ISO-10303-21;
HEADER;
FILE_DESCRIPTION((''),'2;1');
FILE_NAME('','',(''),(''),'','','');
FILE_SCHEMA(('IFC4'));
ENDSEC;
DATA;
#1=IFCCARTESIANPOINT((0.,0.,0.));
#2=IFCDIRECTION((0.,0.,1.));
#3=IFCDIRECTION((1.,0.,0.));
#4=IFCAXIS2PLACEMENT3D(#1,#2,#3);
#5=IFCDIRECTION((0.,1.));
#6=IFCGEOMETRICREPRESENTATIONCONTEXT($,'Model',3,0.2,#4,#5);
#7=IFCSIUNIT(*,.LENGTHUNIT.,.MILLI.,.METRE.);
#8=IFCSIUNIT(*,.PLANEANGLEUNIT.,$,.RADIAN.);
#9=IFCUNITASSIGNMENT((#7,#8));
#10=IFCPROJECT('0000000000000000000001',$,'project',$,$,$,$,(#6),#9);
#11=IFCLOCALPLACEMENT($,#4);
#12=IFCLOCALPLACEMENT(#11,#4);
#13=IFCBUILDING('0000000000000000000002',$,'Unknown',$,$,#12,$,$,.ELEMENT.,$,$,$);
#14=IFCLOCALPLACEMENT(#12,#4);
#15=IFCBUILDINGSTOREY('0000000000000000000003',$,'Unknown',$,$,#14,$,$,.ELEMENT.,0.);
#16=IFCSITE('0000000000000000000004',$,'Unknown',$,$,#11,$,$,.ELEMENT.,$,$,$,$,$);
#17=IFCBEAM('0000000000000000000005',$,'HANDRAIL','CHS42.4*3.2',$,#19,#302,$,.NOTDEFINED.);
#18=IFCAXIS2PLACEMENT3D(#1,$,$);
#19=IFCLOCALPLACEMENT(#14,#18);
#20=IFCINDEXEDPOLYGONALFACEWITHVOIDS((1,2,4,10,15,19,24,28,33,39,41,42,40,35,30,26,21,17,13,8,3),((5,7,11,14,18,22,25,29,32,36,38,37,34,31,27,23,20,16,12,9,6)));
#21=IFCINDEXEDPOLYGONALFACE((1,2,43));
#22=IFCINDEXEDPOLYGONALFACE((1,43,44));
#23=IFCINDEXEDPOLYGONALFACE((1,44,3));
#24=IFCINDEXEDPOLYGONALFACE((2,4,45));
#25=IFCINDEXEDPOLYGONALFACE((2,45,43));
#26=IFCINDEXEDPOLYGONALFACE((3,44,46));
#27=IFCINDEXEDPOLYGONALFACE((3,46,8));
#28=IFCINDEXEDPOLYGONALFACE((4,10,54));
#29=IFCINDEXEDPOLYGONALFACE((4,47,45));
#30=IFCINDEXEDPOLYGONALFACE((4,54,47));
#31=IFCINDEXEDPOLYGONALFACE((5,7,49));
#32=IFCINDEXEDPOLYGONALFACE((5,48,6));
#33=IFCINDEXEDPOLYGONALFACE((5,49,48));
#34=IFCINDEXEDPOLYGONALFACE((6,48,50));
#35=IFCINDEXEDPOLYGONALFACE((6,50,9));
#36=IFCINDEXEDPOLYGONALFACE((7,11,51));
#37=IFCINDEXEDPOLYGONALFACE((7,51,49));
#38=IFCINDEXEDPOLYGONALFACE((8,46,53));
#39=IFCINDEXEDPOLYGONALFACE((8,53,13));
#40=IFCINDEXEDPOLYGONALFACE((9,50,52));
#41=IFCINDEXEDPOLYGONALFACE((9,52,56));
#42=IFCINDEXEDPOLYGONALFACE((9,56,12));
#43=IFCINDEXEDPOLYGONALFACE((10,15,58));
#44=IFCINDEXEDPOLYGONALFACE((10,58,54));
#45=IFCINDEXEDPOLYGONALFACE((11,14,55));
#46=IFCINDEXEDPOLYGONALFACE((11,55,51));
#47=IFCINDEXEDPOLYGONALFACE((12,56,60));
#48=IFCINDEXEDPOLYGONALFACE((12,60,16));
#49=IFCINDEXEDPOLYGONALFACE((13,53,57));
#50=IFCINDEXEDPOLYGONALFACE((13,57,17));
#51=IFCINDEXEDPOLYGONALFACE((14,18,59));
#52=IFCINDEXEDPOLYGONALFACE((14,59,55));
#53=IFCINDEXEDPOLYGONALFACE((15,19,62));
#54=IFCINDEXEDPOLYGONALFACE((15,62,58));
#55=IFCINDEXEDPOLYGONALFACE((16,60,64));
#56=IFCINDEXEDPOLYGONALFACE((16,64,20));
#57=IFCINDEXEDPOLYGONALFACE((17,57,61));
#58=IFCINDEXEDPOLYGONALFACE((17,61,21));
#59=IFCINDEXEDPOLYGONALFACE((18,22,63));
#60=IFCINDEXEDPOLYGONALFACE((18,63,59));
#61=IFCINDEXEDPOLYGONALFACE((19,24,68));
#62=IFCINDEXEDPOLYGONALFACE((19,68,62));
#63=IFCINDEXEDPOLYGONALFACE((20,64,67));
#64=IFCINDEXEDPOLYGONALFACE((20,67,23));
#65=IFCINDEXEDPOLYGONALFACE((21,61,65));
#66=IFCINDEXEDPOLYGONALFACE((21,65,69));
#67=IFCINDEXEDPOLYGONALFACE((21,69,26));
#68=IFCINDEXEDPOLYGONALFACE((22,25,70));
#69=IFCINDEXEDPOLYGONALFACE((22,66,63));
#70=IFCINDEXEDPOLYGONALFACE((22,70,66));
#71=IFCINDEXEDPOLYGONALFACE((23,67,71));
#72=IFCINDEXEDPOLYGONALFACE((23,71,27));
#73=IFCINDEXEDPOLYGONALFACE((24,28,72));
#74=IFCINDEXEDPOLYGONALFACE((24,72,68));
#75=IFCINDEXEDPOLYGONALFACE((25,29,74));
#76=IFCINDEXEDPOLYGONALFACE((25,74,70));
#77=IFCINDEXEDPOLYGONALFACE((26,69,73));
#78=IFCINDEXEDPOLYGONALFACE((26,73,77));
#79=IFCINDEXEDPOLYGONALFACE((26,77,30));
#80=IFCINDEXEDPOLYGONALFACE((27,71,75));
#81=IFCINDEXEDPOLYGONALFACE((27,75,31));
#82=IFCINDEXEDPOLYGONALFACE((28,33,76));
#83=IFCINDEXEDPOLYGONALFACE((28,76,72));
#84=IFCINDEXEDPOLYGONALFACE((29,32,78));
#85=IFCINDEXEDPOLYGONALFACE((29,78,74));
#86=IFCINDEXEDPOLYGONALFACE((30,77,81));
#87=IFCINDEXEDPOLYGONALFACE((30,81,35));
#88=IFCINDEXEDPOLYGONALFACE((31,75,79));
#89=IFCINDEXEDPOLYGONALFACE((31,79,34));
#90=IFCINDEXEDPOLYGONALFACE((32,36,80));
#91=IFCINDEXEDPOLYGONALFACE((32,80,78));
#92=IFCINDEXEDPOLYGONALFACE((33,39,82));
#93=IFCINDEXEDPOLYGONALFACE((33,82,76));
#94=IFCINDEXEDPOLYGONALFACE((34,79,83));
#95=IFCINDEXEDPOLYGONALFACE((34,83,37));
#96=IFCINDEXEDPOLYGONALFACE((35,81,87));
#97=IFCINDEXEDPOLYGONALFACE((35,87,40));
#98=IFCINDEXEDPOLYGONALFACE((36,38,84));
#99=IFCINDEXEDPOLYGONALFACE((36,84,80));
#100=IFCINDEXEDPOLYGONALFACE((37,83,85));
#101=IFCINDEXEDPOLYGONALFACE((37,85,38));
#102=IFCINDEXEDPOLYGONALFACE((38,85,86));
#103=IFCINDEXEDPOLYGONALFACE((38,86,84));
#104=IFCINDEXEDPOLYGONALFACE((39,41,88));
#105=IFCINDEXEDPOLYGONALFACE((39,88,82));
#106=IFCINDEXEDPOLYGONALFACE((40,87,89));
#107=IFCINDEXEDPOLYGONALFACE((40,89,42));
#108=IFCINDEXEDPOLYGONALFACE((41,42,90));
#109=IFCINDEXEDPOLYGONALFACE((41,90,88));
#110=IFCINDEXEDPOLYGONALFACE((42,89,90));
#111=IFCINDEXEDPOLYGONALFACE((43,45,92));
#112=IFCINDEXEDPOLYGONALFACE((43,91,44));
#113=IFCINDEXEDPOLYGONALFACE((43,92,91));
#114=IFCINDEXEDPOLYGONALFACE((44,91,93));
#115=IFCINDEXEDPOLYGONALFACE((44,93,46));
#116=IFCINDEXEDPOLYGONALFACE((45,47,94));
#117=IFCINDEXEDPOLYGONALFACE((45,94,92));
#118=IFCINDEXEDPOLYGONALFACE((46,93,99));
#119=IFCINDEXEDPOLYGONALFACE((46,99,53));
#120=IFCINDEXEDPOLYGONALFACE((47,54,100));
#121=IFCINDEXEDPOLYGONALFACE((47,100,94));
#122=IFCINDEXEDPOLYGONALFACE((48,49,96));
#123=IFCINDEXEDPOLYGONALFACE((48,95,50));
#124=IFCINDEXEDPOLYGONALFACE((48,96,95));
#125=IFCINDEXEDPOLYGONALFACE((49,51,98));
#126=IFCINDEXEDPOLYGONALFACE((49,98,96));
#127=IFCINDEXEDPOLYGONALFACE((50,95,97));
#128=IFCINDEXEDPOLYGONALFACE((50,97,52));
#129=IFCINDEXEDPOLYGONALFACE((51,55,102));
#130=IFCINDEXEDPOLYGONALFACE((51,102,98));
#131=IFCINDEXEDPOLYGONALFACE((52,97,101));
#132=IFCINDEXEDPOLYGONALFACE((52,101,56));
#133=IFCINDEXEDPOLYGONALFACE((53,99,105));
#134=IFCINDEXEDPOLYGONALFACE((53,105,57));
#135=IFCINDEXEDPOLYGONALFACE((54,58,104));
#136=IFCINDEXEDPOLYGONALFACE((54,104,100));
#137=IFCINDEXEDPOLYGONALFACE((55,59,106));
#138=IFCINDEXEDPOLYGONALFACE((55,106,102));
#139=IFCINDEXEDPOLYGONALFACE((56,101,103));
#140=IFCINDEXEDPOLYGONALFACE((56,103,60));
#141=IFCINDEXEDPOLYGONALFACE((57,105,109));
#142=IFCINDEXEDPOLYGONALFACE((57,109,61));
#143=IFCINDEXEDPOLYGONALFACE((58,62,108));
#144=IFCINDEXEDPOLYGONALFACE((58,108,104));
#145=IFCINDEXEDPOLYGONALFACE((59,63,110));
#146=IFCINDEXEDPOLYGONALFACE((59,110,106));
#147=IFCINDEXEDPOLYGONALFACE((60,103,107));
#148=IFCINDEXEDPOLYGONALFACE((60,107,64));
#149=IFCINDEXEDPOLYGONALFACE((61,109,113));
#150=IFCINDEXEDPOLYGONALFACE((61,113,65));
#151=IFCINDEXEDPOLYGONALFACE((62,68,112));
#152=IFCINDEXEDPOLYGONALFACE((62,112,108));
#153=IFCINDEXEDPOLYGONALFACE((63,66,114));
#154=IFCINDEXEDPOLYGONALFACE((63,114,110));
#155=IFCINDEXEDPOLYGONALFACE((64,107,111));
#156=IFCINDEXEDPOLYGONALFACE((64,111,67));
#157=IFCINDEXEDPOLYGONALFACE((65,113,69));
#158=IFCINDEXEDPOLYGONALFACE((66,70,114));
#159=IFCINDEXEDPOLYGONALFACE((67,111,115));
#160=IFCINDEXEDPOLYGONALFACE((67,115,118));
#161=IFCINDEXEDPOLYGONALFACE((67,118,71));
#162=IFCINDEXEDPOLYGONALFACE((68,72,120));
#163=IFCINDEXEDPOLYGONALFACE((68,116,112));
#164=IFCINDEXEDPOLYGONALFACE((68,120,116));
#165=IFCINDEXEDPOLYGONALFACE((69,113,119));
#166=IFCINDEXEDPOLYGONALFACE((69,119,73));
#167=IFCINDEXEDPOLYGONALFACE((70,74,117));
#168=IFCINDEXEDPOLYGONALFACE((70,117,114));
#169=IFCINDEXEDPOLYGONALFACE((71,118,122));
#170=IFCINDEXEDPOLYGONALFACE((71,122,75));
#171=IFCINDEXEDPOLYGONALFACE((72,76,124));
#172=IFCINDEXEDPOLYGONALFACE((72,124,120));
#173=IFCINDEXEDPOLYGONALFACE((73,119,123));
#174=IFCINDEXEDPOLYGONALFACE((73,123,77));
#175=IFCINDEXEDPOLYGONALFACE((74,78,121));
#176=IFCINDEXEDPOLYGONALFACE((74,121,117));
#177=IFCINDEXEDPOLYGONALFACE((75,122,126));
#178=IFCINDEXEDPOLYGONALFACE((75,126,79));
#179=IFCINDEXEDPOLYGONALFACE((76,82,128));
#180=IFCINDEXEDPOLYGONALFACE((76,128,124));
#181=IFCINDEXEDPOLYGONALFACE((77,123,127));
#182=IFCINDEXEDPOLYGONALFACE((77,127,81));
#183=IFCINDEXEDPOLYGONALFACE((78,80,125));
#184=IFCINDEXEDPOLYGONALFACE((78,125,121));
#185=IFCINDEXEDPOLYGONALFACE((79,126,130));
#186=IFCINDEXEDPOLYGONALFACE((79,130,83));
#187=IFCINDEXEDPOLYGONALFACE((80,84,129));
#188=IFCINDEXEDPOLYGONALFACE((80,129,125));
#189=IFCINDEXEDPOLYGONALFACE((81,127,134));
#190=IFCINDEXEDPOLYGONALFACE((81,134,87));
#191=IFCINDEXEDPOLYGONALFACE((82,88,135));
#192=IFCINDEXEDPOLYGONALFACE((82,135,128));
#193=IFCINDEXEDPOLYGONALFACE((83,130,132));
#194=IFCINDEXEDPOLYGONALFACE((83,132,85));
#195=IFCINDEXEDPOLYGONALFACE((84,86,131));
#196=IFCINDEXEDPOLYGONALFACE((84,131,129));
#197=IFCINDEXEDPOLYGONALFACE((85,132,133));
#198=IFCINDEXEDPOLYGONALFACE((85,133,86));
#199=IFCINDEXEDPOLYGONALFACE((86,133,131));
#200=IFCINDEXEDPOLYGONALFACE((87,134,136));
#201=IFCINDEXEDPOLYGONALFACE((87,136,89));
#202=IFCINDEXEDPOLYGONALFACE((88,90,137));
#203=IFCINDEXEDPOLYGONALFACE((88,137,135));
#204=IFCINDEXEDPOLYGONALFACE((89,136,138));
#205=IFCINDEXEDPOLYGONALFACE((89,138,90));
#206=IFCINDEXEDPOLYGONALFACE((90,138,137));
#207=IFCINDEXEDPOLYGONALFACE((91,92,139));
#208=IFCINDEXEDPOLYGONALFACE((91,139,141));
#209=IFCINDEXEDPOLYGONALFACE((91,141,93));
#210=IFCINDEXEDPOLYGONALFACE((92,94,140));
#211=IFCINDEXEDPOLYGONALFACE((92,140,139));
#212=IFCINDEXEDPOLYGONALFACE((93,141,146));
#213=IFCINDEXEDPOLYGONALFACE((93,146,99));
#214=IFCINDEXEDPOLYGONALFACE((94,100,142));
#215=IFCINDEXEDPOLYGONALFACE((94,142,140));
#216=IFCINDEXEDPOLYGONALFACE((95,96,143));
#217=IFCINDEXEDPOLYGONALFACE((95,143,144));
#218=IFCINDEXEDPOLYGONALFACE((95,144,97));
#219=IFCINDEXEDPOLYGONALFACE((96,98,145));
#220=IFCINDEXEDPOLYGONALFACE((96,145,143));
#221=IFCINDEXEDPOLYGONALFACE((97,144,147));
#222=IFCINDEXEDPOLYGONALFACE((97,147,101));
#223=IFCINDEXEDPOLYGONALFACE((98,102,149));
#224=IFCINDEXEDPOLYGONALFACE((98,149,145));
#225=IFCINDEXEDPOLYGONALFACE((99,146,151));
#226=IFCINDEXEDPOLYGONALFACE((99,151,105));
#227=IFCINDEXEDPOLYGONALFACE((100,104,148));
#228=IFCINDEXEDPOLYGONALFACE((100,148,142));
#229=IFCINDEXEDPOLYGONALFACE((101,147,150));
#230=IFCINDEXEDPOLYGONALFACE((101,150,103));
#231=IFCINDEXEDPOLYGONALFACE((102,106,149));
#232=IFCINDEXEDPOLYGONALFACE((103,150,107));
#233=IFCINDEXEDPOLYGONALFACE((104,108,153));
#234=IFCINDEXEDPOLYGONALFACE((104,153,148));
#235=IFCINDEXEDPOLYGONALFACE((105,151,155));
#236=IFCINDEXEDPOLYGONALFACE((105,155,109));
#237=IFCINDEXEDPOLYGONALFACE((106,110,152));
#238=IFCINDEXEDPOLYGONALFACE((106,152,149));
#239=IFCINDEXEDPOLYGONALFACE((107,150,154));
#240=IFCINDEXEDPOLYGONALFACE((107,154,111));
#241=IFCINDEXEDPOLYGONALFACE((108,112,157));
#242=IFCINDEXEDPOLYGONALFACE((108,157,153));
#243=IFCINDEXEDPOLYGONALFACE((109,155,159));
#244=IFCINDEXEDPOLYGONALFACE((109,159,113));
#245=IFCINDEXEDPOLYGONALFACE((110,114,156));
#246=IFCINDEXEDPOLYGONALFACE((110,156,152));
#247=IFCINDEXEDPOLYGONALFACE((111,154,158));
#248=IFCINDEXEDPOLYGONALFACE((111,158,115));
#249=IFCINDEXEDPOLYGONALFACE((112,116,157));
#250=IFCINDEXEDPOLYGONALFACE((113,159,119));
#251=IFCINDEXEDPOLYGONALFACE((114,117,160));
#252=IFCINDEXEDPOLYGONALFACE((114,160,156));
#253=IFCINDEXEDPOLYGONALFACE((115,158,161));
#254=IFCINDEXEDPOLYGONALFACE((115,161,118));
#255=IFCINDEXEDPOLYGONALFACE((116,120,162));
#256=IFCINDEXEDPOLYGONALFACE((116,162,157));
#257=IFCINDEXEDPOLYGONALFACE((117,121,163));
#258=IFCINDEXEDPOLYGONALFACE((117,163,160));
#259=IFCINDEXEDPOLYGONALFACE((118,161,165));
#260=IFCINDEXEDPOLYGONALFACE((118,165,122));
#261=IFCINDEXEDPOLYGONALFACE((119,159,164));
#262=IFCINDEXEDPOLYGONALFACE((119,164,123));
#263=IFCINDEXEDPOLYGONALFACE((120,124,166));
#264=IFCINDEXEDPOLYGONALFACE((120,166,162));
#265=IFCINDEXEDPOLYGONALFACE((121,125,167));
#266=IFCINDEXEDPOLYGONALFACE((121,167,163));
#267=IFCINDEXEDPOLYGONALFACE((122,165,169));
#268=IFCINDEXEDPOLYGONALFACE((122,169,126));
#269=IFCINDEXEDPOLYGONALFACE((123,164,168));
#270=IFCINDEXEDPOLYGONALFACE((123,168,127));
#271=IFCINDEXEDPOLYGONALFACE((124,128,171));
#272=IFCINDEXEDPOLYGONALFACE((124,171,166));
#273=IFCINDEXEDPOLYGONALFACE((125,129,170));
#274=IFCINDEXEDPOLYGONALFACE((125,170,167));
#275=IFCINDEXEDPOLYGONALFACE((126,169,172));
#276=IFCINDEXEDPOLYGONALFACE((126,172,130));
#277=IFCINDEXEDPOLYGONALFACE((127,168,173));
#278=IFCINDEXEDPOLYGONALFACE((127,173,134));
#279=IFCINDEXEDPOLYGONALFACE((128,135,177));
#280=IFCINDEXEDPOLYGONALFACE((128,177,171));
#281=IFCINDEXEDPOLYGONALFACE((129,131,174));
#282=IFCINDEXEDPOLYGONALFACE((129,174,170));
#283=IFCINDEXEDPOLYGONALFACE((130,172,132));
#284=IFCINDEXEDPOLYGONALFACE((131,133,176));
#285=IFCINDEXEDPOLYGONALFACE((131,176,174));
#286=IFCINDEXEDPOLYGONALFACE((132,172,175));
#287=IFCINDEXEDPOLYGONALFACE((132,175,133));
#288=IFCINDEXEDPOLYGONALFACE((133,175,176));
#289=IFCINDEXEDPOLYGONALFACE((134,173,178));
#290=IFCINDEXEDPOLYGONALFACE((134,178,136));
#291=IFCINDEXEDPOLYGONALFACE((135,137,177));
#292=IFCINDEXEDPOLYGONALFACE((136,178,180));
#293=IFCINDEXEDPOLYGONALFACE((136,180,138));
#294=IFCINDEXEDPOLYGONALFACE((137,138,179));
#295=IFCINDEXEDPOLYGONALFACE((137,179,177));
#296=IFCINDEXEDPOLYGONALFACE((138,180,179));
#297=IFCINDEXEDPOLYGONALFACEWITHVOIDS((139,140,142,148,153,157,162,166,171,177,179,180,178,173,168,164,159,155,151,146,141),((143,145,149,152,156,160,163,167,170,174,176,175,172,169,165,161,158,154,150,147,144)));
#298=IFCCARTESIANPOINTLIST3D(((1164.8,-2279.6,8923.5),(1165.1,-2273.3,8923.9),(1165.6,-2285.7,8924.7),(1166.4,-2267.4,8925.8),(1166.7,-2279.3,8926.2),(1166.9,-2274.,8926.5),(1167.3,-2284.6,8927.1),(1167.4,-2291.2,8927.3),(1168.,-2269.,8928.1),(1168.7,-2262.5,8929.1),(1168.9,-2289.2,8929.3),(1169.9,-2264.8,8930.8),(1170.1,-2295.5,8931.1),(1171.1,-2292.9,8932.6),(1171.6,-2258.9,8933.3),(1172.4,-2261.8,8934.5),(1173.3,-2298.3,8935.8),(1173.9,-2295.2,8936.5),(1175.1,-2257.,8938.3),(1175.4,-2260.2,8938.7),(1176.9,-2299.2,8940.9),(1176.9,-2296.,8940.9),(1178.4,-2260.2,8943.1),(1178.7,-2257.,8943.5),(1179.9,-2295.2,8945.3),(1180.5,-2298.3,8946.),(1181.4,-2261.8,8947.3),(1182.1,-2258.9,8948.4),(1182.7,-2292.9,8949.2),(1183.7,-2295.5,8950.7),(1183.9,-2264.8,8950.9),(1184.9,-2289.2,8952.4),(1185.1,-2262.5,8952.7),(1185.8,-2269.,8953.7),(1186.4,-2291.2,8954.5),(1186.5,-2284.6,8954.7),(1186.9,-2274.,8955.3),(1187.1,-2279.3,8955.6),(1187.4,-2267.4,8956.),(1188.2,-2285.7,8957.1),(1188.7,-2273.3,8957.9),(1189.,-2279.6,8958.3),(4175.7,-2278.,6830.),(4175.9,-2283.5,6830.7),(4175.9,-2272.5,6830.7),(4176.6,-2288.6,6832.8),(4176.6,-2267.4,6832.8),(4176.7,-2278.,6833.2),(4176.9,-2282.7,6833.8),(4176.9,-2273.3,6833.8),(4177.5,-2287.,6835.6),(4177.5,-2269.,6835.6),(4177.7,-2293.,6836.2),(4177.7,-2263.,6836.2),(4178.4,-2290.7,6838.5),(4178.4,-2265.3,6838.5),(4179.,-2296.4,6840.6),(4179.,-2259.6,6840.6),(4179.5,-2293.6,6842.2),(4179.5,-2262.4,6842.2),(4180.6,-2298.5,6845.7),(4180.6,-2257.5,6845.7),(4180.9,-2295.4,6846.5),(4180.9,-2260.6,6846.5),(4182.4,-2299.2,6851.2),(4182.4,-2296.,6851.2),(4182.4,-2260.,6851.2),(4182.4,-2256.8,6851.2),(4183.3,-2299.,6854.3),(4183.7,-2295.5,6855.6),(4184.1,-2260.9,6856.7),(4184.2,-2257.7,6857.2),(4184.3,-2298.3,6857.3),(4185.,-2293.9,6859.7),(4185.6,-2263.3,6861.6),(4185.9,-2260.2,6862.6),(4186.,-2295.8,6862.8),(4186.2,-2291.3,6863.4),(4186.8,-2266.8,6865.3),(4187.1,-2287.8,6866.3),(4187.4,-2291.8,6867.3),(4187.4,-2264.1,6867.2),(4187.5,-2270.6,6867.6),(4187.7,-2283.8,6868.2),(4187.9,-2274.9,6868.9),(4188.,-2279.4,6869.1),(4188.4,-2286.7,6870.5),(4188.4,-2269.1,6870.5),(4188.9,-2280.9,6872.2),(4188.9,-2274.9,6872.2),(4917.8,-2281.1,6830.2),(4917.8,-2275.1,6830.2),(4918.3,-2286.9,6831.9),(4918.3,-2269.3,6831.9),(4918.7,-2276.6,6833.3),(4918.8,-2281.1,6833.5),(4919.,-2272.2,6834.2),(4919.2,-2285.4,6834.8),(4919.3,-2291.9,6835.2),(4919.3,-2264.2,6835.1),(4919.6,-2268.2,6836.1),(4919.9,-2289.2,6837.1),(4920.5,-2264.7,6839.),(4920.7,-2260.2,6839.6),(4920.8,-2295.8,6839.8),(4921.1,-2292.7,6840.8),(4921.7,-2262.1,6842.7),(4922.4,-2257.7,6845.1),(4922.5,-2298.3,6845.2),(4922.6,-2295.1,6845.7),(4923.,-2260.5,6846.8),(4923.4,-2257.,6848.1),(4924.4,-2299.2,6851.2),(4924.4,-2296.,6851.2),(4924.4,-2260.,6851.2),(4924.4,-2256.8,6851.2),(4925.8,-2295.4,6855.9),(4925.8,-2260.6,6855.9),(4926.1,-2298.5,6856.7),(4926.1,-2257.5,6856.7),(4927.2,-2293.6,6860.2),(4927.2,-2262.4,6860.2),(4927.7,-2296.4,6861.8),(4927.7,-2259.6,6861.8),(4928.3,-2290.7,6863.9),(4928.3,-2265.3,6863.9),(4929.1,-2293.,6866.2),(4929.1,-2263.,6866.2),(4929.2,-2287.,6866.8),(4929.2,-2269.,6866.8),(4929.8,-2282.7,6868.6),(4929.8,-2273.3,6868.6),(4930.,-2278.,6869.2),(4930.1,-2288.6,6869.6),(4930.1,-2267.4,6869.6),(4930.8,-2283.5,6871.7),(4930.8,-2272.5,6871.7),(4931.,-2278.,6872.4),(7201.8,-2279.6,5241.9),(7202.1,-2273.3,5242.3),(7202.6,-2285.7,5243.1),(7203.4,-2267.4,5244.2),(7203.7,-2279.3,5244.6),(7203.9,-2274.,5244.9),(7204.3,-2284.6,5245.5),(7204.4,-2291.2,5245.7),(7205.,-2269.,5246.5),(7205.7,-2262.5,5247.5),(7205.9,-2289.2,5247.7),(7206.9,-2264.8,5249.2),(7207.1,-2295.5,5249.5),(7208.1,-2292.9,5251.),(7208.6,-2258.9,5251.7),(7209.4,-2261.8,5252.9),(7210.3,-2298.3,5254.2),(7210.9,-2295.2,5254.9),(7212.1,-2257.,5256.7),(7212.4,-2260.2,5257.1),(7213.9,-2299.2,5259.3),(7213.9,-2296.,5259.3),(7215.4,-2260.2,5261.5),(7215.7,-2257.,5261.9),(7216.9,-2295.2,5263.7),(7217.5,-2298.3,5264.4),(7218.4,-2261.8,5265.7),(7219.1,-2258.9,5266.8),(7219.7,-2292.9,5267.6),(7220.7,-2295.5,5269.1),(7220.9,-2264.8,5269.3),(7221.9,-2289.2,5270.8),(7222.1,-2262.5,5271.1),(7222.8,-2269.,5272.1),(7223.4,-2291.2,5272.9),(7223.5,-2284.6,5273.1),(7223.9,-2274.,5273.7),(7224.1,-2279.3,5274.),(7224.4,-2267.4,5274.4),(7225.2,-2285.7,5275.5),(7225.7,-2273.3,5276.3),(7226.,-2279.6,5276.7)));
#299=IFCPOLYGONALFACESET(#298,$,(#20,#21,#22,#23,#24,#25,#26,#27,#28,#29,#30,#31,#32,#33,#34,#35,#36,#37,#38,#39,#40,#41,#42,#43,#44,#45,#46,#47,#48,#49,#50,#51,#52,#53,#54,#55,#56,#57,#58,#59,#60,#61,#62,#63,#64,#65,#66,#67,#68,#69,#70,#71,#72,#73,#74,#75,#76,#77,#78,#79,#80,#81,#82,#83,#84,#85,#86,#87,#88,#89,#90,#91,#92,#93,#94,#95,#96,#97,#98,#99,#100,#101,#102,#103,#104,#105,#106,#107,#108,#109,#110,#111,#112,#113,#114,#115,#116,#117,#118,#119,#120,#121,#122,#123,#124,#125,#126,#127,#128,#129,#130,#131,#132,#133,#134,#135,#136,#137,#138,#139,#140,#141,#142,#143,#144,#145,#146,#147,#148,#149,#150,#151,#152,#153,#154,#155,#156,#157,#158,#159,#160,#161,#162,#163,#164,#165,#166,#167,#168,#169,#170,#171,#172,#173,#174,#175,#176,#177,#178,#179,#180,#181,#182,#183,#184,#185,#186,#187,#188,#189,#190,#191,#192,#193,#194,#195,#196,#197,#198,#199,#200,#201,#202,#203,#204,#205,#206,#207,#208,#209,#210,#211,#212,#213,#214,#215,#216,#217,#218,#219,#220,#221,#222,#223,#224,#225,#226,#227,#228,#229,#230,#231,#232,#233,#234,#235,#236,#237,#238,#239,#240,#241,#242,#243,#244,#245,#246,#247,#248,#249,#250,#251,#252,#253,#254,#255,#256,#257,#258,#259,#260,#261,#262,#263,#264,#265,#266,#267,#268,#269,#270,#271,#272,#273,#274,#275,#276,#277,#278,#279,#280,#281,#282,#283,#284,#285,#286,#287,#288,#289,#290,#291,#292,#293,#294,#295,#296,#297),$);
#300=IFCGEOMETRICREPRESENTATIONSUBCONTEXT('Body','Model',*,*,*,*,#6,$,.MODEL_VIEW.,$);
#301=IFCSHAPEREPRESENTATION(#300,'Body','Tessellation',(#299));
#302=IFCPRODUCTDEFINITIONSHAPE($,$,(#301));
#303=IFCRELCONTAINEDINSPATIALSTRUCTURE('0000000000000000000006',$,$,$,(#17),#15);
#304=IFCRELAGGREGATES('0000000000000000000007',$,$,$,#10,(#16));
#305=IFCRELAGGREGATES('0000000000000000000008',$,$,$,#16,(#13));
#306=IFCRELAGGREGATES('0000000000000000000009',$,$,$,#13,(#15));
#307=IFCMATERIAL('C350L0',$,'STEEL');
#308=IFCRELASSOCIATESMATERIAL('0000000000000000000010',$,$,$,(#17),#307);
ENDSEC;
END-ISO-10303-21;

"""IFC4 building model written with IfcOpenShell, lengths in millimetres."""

from ifc_helpers import new_model, entity, si_unit, direction, frame, origin_with_axes, place, context, subcontext, project, spatial, material, element, save


model = new_model("IFC4")

# Units and contexts
model_context = context("Model", 3, precision=0.2, world=origin_with_axes(), true_north=direction((0.0, 1.0)))
body_context = subcontext(model_context, "Body", "Model", "MODEL_VIEW")
ifc_project = project(units=[si_unit("LENGTHUNIT", "METRE", prefix="MILLI"), si_unit("PLANEANGLEUNIT", "RADIAN")], contexts=[model_context])

# Site, building, storey
site_placement = place(None, origin_with_axes())
site = spatial("IfcSite", under=ifc_project, at=site_placement, Name="Unknown", CompositionType="ELEMENT")
building_placement = place(site_placement, origin_with_axes())
building = spatial("IfcBuilding", under=site, at=building_placement, Name="Unknown", CompositionType="ELEMENT")
storey_placement = place(building_placement, origin_with_axes())
storey = spatial("IfcBuildingStorey", under=building, at=storey_placement, Name="Unknown", CompositionType="ELEMENT", Elevation=0.0)

# Shared definitions
ifc_material_1 = material(Name="C350L0", Category="STEEL")

# Beam
for number, where, z_axis, x_axis, name in (
    (1, (1176.9, -2278.0, 8940.9), (0.0, -1.0, 0.0), (0.821041, 0.0, -0.57087), "HANDRAIL"),
):
    element("IfcBeam", number, at=place(storey_placement, frame(where, z_axis=z_axis, x_axis=x_axis)), inside=storey, material=ifc_material_1, Name=name, Description="CHS42.4*3.2", PredefinedType="NOTDEFINED", context=body_context, shape_type="SolidModel", body=[
        entity("IfcSweptDiskSolid", entity("IfcIndexedPolyCurve", entity("IfcCartesianPointList3D", [[0.0, 0.0, 0.0], [3660.5, 0.0, 0.0], [4269.8, 423.6, 0.0], [7058.3, 423.6, 0.0]]), [entity("IfcLineIndex", [1, 2, 3, 4])]), 21.2, 18.0),
    ])

save(model, "model.ifc")
